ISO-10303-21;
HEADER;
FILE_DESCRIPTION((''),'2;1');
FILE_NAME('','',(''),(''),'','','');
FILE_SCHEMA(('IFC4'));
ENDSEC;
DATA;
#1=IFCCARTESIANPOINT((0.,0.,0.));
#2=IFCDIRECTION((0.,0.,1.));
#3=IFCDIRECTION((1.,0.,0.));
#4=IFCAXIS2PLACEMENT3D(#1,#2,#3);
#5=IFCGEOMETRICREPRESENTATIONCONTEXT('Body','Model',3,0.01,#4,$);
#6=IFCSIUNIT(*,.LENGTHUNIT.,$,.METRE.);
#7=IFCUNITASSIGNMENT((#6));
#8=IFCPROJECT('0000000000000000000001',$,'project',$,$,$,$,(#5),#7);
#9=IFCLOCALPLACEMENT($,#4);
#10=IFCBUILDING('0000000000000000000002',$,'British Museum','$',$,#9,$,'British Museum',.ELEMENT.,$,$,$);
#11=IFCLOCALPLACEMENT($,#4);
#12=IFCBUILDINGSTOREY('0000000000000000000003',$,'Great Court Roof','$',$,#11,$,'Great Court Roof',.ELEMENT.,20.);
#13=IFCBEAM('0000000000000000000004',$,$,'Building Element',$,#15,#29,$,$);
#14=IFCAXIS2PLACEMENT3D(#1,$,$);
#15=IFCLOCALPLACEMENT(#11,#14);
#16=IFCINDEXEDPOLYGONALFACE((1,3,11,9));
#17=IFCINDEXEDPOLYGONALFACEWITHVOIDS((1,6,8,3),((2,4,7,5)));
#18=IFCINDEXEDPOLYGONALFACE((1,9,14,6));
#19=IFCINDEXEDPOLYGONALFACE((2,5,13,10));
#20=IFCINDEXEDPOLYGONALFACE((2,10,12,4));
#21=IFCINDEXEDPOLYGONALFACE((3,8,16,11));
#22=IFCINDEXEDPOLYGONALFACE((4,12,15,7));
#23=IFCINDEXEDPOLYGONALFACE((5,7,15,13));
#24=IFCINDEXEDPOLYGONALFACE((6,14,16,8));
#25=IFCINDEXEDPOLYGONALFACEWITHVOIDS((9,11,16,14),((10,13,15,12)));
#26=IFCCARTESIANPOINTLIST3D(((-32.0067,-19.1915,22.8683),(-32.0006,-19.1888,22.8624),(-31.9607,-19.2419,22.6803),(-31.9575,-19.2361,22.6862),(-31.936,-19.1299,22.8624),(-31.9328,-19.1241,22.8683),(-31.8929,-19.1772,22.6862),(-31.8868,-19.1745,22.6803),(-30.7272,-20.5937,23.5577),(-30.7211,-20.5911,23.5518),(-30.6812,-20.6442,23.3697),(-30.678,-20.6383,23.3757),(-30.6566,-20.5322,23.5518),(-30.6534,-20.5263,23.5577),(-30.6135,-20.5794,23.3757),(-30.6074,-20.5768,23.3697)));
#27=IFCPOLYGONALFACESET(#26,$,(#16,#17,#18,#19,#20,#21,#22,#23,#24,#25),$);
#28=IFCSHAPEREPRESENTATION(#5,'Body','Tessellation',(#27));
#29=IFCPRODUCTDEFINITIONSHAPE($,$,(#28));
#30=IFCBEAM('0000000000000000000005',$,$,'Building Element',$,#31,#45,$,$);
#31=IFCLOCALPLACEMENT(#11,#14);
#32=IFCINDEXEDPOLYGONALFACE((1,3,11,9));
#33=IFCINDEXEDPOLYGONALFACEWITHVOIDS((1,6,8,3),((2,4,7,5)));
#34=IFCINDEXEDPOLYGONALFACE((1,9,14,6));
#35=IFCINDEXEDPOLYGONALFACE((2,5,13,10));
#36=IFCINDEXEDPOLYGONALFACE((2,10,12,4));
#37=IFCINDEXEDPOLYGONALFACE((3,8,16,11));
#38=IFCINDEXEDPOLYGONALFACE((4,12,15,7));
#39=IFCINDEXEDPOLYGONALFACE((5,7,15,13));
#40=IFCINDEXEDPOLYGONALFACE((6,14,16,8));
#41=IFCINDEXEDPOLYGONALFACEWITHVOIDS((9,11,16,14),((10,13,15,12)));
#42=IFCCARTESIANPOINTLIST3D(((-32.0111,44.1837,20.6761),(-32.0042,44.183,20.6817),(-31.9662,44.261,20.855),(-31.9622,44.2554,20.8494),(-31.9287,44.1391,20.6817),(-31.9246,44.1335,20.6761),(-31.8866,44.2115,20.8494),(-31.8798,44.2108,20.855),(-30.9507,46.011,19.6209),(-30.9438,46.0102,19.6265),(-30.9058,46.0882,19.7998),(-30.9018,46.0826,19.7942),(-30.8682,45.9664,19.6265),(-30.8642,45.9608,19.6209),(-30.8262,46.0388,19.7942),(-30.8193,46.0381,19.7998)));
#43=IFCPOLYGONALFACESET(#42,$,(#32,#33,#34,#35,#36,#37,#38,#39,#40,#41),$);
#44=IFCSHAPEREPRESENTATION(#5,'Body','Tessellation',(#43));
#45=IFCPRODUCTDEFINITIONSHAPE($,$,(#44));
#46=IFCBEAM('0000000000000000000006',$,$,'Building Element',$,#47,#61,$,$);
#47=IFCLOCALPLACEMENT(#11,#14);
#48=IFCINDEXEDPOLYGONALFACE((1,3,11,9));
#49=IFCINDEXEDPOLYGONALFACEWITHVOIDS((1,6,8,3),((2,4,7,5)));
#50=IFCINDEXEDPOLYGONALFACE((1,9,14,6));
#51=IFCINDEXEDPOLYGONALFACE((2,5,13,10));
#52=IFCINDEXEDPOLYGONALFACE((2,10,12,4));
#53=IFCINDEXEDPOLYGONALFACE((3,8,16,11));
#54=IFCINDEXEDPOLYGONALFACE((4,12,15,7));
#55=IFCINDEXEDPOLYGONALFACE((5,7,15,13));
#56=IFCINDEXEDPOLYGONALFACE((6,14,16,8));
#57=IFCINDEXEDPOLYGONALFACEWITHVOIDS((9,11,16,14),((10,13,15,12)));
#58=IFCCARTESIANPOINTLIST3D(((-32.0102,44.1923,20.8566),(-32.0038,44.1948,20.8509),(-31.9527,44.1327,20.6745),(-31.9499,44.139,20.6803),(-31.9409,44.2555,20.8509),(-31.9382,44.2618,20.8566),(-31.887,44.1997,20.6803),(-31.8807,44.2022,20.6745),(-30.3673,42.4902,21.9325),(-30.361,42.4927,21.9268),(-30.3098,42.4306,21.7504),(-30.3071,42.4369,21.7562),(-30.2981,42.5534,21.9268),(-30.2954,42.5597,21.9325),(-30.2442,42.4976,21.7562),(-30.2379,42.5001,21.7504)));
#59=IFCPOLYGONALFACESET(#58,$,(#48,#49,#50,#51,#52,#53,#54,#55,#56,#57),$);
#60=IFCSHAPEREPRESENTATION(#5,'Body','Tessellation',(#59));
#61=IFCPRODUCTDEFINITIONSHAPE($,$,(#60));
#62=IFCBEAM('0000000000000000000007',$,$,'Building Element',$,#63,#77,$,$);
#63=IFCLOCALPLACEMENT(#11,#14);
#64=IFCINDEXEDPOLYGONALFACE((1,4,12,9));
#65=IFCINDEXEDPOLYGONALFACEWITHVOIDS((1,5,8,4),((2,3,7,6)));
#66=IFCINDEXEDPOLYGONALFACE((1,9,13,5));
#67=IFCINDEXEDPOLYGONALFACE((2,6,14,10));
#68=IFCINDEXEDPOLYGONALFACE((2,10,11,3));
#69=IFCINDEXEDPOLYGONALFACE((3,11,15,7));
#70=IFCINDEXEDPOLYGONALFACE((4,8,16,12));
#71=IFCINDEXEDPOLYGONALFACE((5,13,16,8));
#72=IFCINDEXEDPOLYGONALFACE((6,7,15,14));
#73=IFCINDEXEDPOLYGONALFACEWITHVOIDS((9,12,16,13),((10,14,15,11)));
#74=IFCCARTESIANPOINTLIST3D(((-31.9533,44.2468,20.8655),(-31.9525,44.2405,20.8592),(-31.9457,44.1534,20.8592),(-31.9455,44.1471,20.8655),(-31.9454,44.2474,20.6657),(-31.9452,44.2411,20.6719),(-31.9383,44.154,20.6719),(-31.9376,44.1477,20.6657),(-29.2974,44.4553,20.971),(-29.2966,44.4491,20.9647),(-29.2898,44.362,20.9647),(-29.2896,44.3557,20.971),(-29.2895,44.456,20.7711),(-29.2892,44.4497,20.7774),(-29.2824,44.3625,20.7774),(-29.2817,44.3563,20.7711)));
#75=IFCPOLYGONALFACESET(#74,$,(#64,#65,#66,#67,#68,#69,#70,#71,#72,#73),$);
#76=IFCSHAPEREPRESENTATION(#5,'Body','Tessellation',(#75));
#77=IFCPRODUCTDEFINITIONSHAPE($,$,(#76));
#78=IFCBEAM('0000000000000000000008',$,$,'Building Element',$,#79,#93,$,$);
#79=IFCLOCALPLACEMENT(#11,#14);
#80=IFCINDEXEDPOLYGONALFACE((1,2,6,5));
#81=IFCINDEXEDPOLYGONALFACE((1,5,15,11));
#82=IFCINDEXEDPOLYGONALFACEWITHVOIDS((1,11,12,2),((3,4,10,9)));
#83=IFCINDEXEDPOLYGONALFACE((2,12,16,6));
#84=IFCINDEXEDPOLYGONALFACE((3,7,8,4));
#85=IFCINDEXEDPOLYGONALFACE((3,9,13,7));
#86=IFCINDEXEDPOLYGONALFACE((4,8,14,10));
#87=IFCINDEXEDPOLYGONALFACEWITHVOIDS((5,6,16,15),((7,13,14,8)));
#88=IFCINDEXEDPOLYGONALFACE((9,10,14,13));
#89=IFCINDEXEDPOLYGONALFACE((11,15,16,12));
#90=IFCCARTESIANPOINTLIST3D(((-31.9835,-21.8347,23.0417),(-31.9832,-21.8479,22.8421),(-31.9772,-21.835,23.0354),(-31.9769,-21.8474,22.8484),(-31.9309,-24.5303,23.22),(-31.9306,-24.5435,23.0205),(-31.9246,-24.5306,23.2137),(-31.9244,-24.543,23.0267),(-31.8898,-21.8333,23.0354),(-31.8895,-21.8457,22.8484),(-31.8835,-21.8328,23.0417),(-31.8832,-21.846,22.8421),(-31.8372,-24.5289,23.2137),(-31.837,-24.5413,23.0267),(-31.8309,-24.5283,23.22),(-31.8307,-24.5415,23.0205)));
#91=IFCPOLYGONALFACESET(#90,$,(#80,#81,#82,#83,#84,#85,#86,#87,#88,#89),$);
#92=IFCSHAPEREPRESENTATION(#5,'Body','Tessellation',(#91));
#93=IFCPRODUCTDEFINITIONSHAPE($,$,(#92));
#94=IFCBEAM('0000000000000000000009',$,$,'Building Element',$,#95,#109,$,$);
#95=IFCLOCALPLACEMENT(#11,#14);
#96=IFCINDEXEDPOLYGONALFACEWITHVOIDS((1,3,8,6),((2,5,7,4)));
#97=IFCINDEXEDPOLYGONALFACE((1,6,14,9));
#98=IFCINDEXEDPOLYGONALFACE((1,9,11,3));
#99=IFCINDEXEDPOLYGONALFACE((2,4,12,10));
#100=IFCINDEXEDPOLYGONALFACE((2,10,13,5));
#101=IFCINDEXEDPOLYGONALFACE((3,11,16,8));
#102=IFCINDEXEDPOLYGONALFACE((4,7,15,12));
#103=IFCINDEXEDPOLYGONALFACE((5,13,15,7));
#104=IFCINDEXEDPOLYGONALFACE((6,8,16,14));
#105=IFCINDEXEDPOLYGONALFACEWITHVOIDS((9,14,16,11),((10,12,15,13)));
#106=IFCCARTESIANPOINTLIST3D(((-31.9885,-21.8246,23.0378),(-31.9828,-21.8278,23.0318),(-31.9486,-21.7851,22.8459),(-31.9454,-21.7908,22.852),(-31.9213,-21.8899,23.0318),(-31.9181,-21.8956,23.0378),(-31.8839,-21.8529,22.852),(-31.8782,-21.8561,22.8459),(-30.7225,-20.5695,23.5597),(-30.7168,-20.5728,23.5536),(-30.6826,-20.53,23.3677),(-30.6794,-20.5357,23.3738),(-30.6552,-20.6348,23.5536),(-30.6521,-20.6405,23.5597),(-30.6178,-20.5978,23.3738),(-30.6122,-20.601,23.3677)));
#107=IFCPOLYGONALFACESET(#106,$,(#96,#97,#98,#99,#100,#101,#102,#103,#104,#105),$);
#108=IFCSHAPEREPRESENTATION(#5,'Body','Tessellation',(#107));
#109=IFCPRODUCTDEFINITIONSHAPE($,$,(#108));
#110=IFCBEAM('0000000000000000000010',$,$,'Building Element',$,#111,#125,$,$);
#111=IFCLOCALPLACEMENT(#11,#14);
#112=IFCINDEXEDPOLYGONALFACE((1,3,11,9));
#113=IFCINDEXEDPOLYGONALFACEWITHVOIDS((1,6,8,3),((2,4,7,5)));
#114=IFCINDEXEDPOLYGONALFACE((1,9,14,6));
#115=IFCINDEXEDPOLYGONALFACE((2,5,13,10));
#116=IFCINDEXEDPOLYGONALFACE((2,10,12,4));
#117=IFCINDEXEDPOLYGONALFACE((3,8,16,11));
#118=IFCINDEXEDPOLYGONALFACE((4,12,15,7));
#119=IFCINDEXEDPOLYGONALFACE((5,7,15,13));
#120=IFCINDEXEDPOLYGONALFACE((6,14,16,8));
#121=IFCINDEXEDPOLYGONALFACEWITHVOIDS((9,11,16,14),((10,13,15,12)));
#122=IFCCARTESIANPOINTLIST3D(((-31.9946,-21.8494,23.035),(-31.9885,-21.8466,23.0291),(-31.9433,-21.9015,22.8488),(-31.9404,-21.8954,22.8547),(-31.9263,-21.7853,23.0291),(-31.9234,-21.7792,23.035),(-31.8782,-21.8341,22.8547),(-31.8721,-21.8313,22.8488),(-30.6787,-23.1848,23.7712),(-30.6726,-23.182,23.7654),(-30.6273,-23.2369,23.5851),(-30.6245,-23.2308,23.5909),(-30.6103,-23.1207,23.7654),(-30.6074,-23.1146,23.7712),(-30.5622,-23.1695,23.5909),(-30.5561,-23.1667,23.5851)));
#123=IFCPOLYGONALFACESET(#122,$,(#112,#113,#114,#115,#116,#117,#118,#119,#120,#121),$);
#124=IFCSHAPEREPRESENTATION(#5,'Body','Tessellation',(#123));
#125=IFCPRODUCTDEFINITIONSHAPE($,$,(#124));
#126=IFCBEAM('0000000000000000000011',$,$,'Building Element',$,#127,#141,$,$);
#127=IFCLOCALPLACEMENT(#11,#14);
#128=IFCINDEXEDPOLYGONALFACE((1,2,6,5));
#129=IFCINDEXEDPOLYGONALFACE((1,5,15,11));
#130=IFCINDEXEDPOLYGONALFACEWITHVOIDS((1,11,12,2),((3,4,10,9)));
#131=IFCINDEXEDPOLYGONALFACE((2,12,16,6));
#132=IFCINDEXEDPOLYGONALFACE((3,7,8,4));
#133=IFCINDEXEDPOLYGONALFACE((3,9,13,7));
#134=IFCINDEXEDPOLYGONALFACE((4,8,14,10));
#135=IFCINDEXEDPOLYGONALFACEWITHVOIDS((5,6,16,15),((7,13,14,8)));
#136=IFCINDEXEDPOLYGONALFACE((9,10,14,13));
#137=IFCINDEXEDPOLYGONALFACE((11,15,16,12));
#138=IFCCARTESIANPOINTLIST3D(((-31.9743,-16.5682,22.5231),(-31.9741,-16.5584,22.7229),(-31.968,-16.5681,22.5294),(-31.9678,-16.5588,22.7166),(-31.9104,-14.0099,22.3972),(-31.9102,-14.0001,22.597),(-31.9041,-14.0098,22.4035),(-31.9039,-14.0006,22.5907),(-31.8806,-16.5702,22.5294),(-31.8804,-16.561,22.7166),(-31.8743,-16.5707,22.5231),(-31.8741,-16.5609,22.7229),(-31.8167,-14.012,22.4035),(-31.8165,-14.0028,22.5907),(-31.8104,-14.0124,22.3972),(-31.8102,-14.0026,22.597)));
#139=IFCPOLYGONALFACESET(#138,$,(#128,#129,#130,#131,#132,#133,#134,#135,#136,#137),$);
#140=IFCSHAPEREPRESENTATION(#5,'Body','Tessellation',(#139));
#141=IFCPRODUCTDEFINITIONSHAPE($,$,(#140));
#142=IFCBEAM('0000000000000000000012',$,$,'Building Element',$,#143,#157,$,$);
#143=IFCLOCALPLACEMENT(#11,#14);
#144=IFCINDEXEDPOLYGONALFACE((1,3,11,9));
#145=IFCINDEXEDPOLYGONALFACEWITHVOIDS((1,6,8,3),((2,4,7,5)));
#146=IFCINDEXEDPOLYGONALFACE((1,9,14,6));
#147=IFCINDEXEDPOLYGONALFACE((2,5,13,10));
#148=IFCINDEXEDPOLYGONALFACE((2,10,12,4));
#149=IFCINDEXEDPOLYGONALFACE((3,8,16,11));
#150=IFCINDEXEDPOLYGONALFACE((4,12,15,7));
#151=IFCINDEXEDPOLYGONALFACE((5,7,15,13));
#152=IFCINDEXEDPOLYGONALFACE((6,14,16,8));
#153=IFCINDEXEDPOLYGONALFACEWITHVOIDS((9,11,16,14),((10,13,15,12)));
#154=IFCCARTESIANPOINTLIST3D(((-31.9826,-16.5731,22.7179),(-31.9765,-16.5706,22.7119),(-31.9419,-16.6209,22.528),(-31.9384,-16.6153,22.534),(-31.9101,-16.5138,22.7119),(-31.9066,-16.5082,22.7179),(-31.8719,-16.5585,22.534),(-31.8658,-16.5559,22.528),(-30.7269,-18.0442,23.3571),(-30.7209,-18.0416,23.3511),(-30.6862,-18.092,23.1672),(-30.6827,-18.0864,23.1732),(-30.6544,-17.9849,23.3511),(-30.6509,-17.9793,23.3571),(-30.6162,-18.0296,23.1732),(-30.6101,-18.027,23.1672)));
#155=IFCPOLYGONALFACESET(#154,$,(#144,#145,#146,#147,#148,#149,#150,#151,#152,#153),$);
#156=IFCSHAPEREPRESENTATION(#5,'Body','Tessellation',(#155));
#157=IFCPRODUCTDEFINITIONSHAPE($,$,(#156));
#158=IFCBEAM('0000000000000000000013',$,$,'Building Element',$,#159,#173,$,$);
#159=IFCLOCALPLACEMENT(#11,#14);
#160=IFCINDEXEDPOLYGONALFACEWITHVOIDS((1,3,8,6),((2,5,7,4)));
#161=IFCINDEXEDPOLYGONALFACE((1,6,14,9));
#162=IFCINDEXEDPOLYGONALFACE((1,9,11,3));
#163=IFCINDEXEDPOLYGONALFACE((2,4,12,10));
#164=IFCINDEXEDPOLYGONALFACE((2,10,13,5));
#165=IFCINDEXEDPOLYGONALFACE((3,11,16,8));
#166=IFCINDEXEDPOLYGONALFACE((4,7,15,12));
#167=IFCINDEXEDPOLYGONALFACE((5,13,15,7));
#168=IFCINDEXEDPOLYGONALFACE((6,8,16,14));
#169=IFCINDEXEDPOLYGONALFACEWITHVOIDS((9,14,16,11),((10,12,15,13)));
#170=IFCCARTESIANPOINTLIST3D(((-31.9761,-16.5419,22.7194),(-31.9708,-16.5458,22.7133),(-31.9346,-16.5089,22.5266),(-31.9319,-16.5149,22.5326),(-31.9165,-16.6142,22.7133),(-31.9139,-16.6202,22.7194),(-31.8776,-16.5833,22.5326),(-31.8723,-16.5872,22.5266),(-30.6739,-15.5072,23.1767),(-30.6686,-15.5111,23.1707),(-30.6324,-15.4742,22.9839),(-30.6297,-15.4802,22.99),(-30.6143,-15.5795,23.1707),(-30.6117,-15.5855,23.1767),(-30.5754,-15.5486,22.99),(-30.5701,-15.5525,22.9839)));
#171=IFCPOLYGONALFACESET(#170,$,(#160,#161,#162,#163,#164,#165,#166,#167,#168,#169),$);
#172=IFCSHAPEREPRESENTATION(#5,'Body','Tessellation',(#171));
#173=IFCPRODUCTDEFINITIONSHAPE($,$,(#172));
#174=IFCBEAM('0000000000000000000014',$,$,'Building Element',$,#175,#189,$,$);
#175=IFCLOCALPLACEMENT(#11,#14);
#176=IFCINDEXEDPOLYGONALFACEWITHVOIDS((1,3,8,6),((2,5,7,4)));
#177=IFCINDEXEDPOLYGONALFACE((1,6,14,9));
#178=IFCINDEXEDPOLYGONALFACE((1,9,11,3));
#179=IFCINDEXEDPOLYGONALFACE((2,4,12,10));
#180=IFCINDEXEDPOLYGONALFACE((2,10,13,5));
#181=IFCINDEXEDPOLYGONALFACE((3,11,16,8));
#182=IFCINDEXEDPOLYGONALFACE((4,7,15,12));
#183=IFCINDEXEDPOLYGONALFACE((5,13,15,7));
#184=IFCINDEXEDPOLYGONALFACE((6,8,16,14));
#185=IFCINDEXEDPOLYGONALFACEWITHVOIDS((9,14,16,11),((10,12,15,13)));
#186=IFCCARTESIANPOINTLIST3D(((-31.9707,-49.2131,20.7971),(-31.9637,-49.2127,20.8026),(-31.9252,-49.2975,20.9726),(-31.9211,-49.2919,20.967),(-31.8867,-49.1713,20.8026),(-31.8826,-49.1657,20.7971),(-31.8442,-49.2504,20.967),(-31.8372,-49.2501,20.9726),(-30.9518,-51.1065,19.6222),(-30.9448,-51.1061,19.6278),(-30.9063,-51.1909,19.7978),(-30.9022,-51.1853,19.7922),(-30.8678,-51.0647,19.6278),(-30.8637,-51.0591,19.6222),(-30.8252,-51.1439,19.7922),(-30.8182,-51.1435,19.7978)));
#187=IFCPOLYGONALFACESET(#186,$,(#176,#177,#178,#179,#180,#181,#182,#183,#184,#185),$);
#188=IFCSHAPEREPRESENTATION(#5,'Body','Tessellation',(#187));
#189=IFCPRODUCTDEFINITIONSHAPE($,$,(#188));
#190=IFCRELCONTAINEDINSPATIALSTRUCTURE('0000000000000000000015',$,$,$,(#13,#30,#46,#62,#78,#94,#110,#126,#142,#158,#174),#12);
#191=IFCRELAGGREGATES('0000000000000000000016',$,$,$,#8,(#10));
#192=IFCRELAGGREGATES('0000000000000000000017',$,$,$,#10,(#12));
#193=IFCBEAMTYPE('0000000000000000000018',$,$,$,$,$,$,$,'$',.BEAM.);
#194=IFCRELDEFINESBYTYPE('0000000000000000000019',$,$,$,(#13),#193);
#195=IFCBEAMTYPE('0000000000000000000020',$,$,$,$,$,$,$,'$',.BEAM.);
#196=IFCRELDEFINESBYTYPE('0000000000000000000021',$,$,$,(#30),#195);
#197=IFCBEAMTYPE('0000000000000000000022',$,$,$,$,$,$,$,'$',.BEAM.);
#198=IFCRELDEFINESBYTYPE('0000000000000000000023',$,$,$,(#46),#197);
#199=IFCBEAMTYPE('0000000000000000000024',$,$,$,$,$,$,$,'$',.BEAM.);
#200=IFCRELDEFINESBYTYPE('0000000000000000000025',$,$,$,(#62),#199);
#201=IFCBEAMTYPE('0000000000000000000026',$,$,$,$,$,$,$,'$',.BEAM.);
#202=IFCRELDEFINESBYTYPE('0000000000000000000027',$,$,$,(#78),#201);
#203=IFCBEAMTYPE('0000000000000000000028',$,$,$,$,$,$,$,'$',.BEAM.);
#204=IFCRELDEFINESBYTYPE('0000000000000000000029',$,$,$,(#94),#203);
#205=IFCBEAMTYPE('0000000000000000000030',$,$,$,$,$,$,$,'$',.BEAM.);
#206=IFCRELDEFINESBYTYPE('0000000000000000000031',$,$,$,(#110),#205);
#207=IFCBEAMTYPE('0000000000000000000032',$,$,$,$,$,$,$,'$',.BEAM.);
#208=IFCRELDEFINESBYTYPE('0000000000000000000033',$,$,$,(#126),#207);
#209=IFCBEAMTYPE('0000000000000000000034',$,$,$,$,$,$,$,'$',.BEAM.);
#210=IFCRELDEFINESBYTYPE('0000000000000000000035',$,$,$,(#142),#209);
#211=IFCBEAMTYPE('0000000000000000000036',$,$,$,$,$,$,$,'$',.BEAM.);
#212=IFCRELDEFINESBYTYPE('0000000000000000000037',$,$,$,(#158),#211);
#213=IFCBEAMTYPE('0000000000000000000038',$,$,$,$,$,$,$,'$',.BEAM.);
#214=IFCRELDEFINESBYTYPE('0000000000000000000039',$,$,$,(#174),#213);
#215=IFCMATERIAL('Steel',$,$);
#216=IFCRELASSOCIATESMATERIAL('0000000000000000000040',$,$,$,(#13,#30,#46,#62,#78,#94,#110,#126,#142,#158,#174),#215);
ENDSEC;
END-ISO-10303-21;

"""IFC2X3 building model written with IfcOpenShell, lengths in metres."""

from ifc_helpers import new_model, si_unit, frame, origin_with_axes, origin_2d, place, context, project, spatial, hollow_rectangle, extrude, material, type_object, element, save


model = new_model("IFC2X3")

# Units and contexts
model_context = context("Model", 3, precision=0.01, world=origin_with_axes(), identifier="Body")
ifc_project = project(units=[si_unit("LENGTHUNIT", "METRE")], contexts=[model_context])

# Building, storey
building_placement = place(None, origin_with_axes())
building = spatial("IfcBuilding", under=ifc_project, at=building_placement, Name="British Museum", Description="$", LongName="British Museum", CompositionType="ELEMENT")
storey_placement = place(None, origin_with_axes())
storey = spatial("IfcBuildingStorey", under=building, at=storey_placement, Name="Great Court Roof", Description="$", LongName="Great Court Roof", CompositionType="ELEMENT", Elevation=20.0)

# Beams
ifc_material = material(Name="Steel")
beam_type_1 = type_object("IfcBeamType", ElementType="$", PredefinedType="BEAM")
beam_1_placement = place(None, origin_with_axes())
element("IfcBeam", 1, at=beam_1_placement, inside=storey, type_object=beam_type_1, material=ifc_material, Description="Building Element", context=model_context, shape_type="SweptSolid", body=[
    extrude(hollow_rectangle(XDim=0.1, YDim=0.2, WallThickness=0.0063, InnerFilletRadius=-0.0063, OuterFilletRadius=0.0, at=origin_2d()), frame((-31.9468, -19.183, 22.7743), z_axis=(0.633526, -0.694342, 0.34137), x_axis=(0.738718, 0.674015, 0.0)), (0.0, 0.0, 1.0), 2.0196),
])
beam_type_2 = type_object("IfcBeamType", ElementType="$", PredefinedType="BEAM")
beam_2_placement = place(None, origin_with_axes())
element("IfcBeam", 2, at=beam_2_placement, inside=storey, type_object=beam_type_2, material=ifc_material, Description="Building Element", context=model_context, shape_type="SweptSolid", body=[
    extrude(hollow_rectangle(XDim=0.1, YDim=0.2, WallThickness=0.0063, InnerFilletRadius=-0.0063, OuterFilletRadius=0.0, at=origin_2d()), frame((-31.9454, 44.1973, 20.7656), z_axis=(0.449043, 0.773753, -0.446841), x_axis=(-0.864902, 0.501941, 0.0)), (0.0, 0.0, 1.0), 2.3615),
])
beam_type_3 = type_object("IfcBeamType", ElementType="$", PredefinedType="BEAM")
beam_3_placement = place(None, origin_with_axes())
element("IfcBeam", 3, at=beam_3_placement, inside=storey, type_object=beam_type_3, material=ifc_material, Description="Building Element", context=model_context, shape_type="SweptSolid", body=[
    extrude(hollow_rectangle(XDim=0.1, YDim=0.2, WallThickness=0.0063, InnerFilletRadius=-0.0063, OuterFilletRadius=0.0, at=origin_2d()), frame((-31.9454, 44.1973, 20.7656), z_axis=(0.632155, -0.654967, 0.414003), x_axis=(0.719526, 0.694466, 0.0)), (0.0, 0.0, 1.0), 2.5988),
])
beam_type_4 = type_object("IfcBeamType", ElementType="$", PredefinedType="BEAM")
beam_4_placement = place(None, origin_with_axes())
element("IfcBeam", 4, at=beam_4_placement, inside=storey, type_object=beam_type_4, material=ifc_material, Description="Building Element", context=model_context, shape_type="SweptSolid", body=[
    extrude(hollow_rectangle(XDim=0.1, YDim=0.2, WallThickness=0.0063, InnerFilletRadius=-0.0063, OuterFilletRadius=0.0, at=origin_2d()), frame((-31.9454, 44.1973, 20.7656), z_axis=(0.996151, 0.078222, 0.039566), x_axis=(-0.078283, 0.996931, 0.0)), (0.0, 0.0, 1.0), 2.6662),
])
beam_type_5 = type_object("IfcBeamType", ElementType="$", PredefinedType="BEAM")
beam_5_placement = place(None, origin_with_axes())
element("IfcBeam", 5, at=beam_5_placement, inside=storey, type_object=beam_type_5, material=ifc_material, Description="Building Element", context=model_context, shape_type="SweptSolid", body=[
    extrude(hollow_rectangle(XDim=0.1, YDim=0.2, WallThickness=0.0063, InnerFilletRadius=-0.0063, OuterFilletRadius=0.0, at=origin_2d()), frame((-31.9334, -21.8404, 22.9419), z_axis=(0.019458, -0.997629, 0.066014), x_axis=(0.99981, 0.019501, 0.0)), (0.0, 0.0, 1.0), 2.702),
])
beam_type_6 = type_object("IfcBeamType", ElementType="$", PredefinedType="BEAM")
beam_6_placement = place(None, origin_with_axes())
element("IfcBeam", 6, at=beam_6_placement, inside=storey, type_object=beam_type_6, material=ifc_material, Description="Building Element", context=model_context, shape_type="SweptSolid", body=[
    extrude(hollow_rectangle(XDim=0.1, YDim=0.2, WallThickness=0.0063, InnerFilletRadius=-0.0063, OuterFilletRadius=0.0, at=origin_2d()), frame((-31.9334, -21.8404, 22.9419), z_axis=(0.681571, 0.675675, 0.280933), x_axis=(-0.704028, 0.710172, 0.0)), (0.0, 0.0, 1.0), 1.8575),
])
beam_type_7 = type_object("IfcBeamType", ElementType="$", PredefinedType="BEAM")
beam_7_placement = place(None, origin_with_axes())
element("IfcBeam", 7, at=beam_7_placement, inside=storey, type_object=beam_type_7, material=ifc_material, Description="Building Element", context=model_context, shape_type="SweptSolid", body=[
    extrude(hollow_rectangle(XDim=0.1, YDim=0.2, WallThickness=0.0063, InnerFilletRadius=-0.0063, OuterFilletRadius=0.0, at=origin_2d()), frame((-31.9334, -21.8404, 22.9419), z_axis=(0.653329, -0.66298, 0.365539), x_axis=(0.712272, 0.701903, 0.0)), (0.0, 0.0, 1.0), 2.0142),
])
beam_type_8 = type_object("IfcBeamType", ElementType="$", PredefinedType="BEAM")
beam_8_placement = place(None, origin_with_axes())
element("IfcBeam", 8, at=beam_8_placement, inside=storey, type_object=beam_type_8, material=ifc_material, Description="Building Element", context=model_context, shape_type="SweptSolid", body=[
    extrude(hollow_rectangle(XDim=0.1, YDim=0.2, WallThickness=0.0063, InnerFilletRadius=-0.0063, OuterFilletRadius=0.0, at=origin_2d()), frame((-31.9242, -16.5645, 22.623), z_axis=(0.024941, 0.998481, -0.049134), x_axis=(-0.999688, 0.024971, 0.0)), (0.0, 0.0, 1.0), 2.5622),
])
beam_type_9 = type_object("IfcBeamType", ElementType="$", PredefinedType="BEAM")
beam_9_placement = place(None, origin_with_axes())
element("IfcBeam", 9, at=beam_9_placement, inside=storey, type_object=beam_type_9, material=ifc_material, Description="Building Element", context=model_context, shape_type="SweptSolid", body=[
    extrude(hollow_rectangle(XDim=0.1, YDim=0.2, WallThickness=0.0063, InnerFilletRadius=-0.0063, OuterFilletRadius=0.0, at=origin_2d()), frame((-31.9242, -16.5645, 22.623), z_axis=(0.616433, -0.722185, 0.313782), x_axis=(0.760599, 0.649222, 0.0)), (0.0, 0.0, 1.0), 2.037),
])
beam_type_10 = type_object("IfcBeamType", ElementType="$", PredefinedType="BEAM")
beam_10_placement = place(None, origin_with_axes())
element("IfcBeam", 10, at=beam_10_placement, inside=storey, type_object=beam_type_10, material=ifc_material, Description="Building Element", context=model_context, shape_type="SweptSolid", body=[
    extrude(hollow_rectangle(XDim=0.1, YDim=0.2, WallThickness=0.0063, InnerFilletRadius=-0.0063, OuterFilletRadius=0.0, at=origin_2d()), frame((-31.9242, -16.5645, 22.623), z_axis=(0.754919, 0.599835, 0.265132), x_axis=(-0.622099, 0.782939, 0.0)), (0.0, 0.0, 1.0), 1.725),
])
beam_type_11 = type_object("IfcBeamType", ElementType="$", PredefinedType="BEAM")
beam_11_placement = place(None, origin_with_axes())
element("IfcBeam", 11, at=beam_11_placement, inside=storey, type_object=beam_type_11, material=ifc_material, Description="Building Element", context=model_context, shape_type="SweptSolid", body=[
    extrude(hollow_rectangle(XDim=0.1, YDim=0.2, WallThickness=0.0063, InnerFilletRadius=-0.0063, OuterFilletRadius=0.0, at=origin_2d()), frame((-31.9039, -49.2316, 20.8848), z_axis=(0.415861, -0.772762, -0.479477), x_axis=(0.880586, 0.473886, 0.0)), (0.0, 0.0, 1.0), 2.4502),
])

save(model, "model.ifc")
